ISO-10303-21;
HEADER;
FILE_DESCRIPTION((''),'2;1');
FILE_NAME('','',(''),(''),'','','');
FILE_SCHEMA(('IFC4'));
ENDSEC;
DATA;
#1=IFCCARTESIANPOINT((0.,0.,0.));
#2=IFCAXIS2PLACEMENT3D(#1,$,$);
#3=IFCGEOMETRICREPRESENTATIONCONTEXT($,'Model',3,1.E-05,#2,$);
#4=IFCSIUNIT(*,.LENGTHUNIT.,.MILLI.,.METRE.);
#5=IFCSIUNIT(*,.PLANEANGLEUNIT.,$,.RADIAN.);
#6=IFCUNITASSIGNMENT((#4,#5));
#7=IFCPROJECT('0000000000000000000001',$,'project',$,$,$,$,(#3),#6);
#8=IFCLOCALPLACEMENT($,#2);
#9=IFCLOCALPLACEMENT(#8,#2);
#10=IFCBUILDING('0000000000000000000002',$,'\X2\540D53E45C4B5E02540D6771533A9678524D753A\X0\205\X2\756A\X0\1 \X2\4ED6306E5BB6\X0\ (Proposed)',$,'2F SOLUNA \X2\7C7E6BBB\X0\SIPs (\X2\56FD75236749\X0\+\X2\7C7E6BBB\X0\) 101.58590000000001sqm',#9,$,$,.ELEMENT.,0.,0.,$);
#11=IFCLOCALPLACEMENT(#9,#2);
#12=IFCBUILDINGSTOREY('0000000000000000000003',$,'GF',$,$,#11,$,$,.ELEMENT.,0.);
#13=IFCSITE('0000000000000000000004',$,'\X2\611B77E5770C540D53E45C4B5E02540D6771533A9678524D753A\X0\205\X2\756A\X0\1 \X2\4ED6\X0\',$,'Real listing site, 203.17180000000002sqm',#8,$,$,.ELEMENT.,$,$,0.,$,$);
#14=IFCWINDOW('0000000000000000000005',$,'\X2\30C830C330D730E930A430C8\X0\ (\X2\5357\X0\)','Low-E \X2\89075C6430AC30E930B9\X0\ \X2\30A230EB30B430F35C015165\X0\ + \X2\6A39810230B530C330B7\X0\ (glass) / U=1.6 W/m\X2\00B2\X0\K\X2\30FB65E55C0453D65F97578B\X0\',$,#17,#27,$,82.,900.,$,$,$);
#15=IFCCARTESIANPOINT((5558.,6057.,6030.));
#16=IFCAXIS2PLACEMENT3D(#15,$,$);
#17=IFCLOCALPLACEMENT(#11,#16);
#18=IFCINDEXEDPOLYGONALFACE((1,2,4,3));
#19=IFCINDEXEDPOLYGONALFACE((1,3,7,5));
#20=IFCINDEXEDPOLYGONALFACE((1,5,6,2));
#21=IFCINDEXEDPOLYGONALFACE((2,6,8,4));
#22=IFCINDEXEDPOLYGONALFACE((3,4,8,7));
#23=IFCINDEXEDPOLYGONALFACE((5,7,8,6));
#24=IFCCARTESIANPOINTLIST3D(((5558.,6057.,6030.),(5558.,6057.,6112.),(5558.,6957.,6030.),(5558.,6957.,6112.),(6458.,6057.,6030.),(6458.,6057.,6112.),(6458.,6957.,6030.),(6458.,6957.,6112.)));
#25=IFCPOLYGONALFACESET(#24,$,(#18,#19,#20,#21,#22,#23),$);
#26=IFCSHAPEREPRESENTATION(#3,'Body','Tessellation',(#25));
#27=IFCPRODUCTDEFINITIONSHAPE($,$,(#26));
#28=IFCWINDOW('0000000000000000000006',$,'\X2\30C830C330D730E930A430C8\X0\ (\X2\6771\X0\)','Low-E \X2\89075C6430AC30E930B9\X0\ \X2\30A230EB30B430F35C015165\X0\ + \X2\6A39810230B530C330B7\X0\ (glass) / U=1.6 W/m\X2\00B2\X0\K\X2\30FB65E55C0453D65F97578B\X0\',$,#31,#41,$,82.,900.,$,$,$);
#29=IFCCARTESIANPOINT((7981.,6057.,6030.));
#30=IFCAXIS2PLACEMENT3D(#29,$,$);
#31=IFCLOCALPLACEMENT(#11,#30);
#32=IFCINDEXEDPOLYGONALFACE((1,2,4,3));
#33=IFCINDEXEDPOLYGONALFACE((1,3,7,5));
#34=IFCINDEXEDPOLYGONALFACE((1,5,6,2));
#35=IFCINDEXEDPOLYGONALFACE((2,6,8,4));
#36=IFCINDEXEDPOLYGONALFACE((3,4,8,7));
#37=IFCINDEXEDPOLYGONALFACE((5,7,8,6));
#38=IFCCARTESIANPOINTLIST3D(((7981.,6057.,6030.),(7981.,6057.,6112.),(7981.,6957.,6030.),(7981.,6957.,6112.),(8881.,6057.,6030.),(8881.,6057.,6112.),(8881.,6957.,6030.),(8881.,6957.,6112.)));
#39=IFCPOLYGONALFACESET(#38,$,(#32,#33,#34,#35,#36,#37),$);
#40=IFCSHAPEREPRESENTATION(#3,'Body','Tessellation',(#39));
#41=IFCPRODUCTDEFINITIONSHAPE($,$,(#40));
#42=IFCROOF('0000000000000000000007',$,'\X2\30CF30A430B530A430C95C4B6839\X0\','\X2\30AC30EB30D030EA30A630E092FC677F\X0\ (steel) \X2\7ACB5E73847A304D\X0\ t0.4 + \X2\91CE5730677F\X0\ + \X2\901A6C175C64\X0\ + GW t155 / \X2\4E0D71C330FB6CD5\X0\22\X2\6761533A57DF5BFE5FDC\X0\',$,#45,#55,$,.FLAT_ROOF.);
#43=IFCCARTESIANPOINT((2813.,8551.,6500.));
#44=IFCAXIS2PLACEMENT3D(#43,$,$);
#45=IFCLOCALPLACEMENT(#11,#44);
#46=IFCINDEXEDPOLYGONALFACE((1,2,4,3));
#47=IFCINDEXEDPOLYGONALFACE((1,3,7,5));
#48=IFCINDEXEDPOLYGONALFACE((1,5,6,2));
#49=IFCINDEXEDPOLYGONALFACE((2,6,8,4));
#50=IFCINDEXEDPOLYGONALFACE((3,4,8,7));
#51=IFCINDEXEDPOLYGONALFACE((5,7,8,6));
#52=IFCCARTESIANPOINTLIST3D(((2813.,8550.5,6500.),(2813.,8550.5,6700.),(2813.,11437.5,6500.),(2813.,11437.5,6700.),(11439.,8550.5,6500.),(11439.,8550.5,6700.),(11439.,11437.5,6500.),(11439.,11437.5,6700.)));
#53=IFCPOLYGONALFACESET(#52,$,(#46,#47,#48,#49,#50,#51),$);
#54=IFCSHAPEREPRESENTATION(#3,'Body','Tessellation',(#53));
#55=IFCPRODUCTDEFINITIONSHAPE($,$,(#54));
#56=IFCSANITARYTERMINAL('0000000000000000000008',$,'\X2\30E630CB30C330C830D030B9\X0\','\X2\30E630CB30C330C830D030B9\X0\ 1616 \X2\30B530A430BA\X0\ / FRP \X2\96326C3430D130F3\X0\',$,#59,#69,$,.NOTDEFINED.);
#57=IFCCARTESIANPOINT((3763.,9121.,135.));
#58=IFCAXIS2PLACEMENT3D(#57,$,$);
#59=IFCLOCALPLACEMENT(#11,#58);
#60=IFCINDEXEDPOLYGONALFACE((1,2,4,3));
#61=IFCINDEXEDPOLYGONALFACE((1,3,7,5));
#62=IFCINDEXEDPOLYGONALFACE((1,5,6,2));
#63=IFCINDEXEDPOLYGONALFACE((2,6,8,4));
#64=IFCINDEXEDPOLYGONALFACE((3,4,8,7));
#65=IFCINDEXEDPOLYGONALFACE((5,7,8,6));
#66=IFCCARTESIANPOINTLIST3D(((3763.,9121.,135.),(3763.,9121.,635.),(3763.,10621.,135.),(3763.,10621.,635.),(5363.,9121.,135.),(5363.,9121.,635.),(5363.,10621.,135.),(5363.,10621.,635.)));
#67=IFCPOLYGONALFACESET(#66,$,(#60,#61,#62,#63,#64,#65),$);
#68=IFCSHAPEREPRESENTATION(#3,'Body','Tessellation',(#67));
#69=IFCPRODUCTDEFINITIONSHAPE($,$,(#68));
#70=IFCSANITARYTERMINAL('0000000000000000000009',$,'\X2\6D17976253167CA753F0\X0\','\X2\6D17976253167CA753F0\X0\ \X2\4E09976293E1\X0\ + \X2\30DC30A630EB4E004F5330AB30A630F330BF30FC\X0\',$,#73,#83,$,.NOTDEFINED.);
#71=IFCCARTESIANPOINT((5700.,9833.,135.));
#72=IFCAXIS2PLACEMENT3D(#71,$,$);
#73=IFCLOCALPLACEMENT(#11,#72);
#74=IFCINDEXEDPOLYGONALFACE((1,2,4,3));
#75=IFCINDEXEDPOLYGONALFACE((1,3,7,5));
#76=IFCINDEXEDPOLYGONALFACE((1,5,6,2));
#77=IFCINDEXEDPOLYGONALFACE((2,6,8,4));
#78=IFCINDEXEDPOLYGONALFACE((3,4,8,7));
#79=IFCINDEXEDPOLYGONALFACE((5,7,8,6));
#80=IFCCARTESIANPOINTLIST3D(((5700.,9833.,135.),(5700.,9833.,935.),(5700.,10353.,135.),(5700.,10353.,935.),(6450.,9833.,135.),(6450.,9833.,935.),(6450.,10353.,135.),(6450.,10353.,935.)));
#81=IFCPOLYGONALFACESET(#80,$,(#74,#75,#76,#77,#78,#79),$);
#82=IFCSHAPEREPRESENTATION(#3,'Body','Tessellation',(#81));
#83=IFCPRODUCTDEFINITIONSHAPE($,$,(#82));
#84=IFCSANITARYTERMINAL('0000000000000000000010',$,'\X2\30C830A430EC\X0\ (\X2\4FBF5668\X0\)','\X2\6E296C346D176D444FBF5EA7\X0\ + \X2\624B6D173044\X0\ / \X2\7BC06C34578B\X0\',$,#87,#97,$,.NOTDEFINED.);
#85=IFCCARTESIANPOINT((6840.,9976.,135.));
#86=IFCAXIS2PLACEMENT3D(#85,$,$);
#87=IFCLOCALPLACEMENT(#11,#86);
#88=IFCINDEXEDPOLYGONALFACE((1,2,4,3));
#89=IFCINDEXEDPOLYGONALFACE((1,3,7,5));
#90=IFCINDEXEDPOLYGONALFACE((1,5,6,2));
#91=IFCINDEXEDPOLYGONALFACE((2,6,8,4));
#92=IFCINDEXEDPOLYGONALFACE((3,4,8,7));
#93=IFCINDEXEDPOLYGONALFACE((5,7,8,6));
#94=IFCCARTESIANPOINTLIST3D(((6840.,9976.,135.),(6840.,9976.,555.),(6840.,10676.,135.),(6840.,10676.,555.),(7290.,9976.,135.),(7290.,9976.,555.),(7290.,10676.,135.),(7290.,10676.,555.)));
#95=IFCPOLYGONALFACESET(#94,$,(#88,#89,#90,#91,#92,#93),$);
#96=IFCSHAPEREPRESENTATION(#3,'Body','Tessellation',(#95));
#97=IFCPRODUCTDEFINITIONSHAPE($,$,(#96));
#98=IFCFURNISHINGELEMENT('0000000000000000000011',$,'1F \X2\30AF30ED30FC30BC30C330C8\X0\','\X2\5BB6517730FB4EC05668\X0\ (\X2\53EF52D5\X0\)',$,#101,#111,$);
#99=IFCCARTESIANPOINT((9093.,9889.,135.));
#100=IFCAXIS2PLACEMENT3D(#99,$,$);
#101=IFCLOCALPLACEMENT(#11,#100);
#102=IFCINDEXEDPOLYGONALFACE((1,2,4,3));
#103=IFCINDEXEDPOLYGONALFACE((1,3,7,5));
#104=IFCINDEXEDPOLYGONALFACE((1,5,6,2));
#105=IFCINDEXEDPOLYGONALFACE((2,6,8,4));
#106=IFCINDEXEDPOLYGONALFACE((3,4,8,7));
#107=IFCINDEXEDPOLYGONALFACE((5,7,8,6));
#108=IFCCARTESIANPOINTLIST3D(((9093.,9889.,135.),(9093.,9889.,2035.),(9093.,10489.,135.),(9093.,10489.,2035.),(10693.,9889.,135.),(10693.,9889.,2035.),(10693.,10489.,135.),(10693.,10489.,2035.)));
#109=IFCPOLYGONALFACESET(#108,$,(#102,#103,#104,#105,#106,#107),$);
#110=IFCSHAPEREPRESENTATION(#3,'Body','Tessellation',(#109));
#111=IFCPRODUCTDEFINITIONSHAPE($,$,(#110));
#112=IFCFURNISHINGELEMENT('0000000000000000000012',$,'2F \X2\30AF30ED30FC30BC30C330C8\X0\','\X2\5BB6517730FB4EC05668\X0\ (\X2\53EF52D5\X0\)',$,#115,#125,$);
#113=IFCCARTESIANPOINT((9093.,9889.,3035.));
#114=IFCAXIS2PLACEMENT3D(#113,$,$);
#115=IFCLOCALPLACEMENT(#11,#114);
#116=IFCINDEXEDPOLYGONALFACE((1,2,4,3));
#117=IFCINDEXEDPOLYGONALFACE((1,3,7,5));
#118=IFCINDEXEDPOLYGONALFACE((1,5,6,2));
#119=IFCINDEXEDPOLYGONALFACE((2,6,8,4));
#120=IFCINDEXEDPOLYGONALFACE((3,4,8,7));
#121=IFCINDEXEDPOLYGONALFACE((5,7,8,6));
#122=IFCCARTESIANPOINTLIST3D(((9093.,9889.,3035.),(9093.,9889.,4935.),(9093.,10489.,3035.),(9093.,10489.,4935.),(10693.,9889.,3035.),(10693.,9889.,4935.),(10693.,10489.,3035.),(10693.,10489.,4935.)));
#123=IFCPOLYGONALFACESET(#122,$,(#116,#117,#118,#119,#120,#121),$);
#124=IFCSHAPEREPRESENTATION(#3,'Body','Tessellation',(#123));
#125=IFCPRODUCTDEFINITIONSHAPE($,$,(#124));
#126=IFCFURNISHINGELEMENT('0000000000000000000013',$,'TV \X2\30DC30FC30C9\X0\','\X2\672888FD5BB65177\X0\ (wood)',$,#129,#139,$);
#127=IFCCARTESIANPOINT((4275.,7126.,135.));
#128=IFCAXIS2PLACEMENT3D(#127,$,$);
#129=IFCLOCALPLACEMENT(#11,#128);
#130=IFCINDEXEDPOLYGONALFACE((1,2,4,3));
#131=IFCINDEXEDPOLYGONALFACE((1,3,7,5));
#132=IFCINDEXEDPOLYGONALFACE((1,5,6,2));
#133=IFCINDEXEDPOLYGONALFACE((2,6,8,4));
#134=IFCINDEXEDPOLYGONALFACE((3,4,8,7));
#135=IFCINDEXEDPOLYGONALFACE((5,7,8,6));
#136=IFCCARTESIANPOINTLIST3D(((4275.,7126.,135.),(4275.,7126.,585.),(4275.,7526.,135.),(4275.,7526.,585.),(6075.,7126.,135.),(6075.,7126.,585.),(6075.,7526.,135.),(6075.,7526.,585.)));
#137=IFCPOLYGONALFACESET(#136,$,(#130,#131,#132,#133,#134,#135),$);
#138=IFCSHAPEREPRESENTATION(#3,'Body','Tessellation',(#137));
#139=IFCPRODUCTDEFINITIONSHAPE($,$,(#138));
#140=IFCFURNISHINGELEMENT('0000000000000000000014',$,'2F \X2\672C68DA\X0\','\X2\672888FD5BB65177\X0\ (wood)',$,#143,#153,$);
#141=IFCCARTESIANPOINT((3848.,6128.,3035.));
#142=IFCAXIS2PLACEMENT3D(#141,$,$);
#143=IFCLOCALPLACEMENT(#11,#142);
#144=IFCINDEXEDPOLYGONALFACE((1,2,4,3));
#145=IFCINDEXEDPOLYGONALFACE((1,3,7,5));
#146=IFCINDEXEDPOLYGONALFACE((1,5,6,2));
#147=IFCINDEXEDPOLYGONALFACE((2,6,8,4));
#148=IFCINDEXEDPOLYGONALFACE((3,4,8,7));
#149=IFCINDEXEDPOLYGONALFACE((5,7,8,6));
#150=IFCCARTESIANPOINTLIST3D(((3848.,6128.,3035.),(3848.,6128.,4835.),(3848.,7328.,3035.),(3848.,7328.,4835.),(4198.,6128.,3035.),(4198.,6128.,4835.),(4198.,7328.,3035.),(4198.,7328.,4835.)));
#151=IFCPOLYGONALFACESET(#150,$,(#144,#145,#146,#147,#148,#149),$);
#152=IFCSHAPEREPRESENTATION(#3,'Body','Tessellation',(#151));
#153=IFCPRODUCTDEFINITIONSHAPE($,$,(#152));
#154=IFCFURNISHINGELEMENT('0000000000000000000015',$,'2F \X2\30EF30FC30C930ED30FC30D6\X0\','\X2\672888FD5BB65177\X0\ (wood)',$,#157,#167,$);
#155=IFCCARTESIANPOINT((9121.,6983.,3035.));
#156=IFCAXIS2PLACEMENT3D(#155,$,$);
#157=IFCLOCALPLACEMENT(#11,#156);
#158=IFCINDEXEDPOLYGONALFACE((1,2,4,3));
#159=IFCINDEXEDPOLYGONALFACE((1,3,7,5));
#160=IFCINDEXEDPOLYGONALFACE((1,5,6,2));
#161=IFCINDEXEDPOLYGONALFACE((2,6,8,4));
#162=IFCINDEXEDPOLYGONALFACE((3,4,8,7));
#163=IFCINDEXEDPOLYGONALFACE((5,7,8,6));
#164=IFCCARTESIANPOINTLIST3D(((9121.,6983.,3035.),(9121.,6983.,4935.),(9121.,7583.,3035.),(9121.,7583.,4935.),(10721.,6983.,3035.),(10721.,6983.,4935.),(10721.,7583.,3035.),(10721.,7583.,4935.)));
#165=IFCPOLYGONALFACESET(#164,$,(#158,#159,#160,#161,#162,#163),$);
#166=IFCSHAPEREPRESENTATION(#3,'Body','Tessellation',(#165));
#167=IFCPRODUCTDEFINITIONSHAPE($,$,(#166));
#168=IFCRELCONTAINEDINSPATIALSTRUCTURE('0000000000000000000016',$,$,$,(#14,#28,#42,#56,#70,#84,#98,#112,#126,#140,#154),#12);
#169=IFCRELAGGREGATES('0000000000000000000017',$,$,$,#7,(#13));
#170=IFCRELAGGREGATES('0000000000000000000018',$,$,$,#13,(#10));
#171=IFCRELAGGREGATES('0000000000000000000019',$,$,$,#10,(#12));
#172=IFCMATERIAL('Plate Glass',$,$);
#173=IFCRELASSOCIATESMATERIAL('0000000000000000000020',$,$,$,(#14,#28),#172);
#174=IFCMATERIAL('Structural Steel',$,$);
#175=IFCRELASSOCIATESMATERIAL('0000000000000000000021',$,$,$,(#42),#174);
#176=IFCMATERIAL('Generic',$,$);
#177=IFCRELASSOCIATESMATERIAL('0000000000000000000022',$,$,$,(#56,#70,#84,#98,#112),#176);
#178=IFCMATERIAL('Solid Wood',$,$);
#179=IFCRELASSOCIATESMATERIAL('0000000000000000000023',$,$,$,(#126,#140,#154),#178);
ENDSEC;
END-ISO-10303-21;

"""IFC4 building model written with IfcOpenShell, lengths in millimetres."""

from ifc_helpers import new_model, si_unit, frame, frame_2d, origin, place, context, project, spatial, rectangle, extrude, material, element, save


model = new_model("IFC4")

# Units and contexts
model_context = context("Model", 3, precision=1e-05, world=origin())
ifc_project = project(units=[si_unit("LENGTHUNIT", "METRE", prefix="MILLI"), si_unit("PLANEANGLEUNIT", "RADIAN")], contexts=[model_context])

# Site, building, storey
site_placement = place(None, origin())
site = spatial("IfcSite", under=ifc_project, at=site_placement, Name="愛知県名古屋市名東区陸前町205番1 他", ObjectType="Real listing site, 203.17180000000002sqm", CompositionType="ELEMENT", RefElevation=0.0)
building_placement = place(site_placement, origin())
building = spatial("IfcBuilding", under=site, at=building_placement, Name="名古屋市名東区陸前町205番1 他の家 (Proposed)", ObjectType="2F SOLUNA 籾殻SIPs (国産杉+籾殻) 101.58590000000001sqm", CompositionType="ELEMENT", ElevationOfRefHeight=0.0, ElevationOfTerrain=0.0)
storey_placement = place(building_placement, origin())
storey = spatial("IfcBuildingStorey", under=building, at=storey_placement, Name="GF", CompositionType="ELEMENT", Elevation=0.0)

# Shared definitions
ifc_material_1 = material(Name="Solid Wood")
ifc_material_2 = material(Name="Plate Glass")

# Windows
window_1_placement = place(storey_placement, frame((5558.0, 6057.0, 6030.0)))
element("IfcWindow", 1, at=window_1_placement, inside=storey, material=ifc_material_2, Name="トップライト (南)", Description="Low-E 複層ガラス アルゴン封入 + 樹脂サッシ (glass) / U=1.6 W/m²K・日射取得型", OverallHeight=82.0, OverallWidth=900.0, context=model_context, shape_type="SweptSolid", body=[
    extrude(rectangle(XDim=900.0, YDim=900.0, at=frame_2d((450.0, 450.0))), frame((5558.0, 6057.0, 6030.0)), (0.0, 0.0, 1.0), 82.0),
])
window_2_placement = place(storey_placement, frame((7981.0, 6057.0, 6030.0)))
element("IfcWindow", 2, at=window_2_placement, inside=storey, material=ifc_material_2, Name="トップライト (東)", Description="Low-E 複層ガラス アルゴン封入 + 樹脂サッシ (glass) / U=1.6 W/m²K・日射取得型", OverallHeight=82.0, OverallWidth=900.0, context=model_context, shape_type="SweptSolid", body=[
    extrude(rectangle(XDim=900.0, YDim=900.0, at=frame_2d((450.0, 450.0))), frame((7981.0, 6057.0, 6030.0)), (0.0, 0.0, 1.0), 82.0),
])

# Roof
ifc_material_3 = material(Name="Structural Steel")
roof_placement = place(storey_placement, frame((2813.0, 8551.0, 6500.0)))
element("IfcRoof", 3, at=roof_placement, inside=storey, material=ifc_material_3, Name="ハイサイド屋根", Description="ガルバリウム鋼板 (steel) 立平葺き t0.4 + 野地板 + 通気層 + GW t155 / 不燃・法22条区域対応", PredefinedType="FLAT_ROOF", context=model_context, shape_type="SweptSolid", body=[
    extrude(rectangle(XDim=8626.0, YDim=2887.0, at=frame_2d((4313.0, 1443.0))), frame((2813.0, 8551.0, 6500.0)), (0.0, 0.0, 1.0), 200.0),
])

# Sanitary terminals
ifc_material_4 = material(Name="Generic")
sanitary_terminal_1_placement = place(storey_placement, frame((3763.0, 9121.0, 135.0)))
element("IfcSanitaryTerminal", 4, at=sanitary_terminal_1_placement, inside=storey, material=ifc_material_4, Name="ユニットバス", Description="ユニットバス 1616 サイズ / FRP 防水パン", PredefinedType="NOTDEFINED", context=model_context, shape_type="SweptSolid", body=[
    extrude(rectangle(XDim=1600.0, YDim=1500.0, at=frame_2d((800.0, 750.0))), frame((3763.0, 9121.0, 135.0)), (0.0, 0.0, 1.0), 500.0),
])
sanitary_terminal_2_placement = place(storey_placement, frame((5700.0, 9833.0, 135.0)))
element("IfcSanitaryTerminal", 5, at=sanitary_terminal_2_placement, inside=storey, material=ifc_material_4, Name="洗面化粧台", Description="洗面化粧台 三面鏡 + ボウル一体カウンター", PredefinedType="NOTDEFINED", context=model_context, shape_type="SweptSolid", body=[
    extrude(rectangle(XDim=750.0, YDim=520.0, at=frame_2d((375.0, 260.0))), frame((5700.0, 9833.0, 135.0)), (0.0, 0.0, 1.0), 800.0),
])
sanitary_terminal_3_placement = place(storey_placement, frame((6840.0, 9976.0, 135.0)))
element("IfcSanitaryTerminal", 6, at=sanitary_terminal_3_placement, inside=storey, material=ifc_material_4, Name="トイレ (便器)", Description="温水洗浄便座 + 手洗い / 節水型", PredefinedType="NOTDEFINED", context=model_context, shape_type="SweptSolid", body=[
    extrude(rectangle(XDim=450.0, YDim=700.0, at=frame_2d((225.0, 350.0))), frame((6840.0, 9976.0, 135.0)), (0.0, 0.0, 1.0), 420.0),
])

# Furnishing elements
furnishing_1_placement = place(storey_placement, frame((9093.0, 9889.0, 135.0)))
element("IfcFurnishingElement", 7, at=furnishing_1_placement, inside=storey, material=ifc_material_4, Name="1F クローゼット", Description="家具・什器 (可動)", context=model_context, shape_type="SweptSolid", body=[
    extrude(rectangle(XDim=1600.0, YDim=600.0, at=frame_2d((800.0, 300.0))), frame((9093.0, 9889.0, 135.0)), (0.0, 0.0, 1.0), 1900.0),
])
furnishing_2_placement = place(storey_placement, frame((9093.0, 9889.0, 3035.0)))
element("IfcFurnishingElement", 8, at=furnishing_2_placement, inside=storey, material=ifc_material_4, Name="2F クローゼット", Description="家具・什器 (可動)", context=model_context, shape_type="SweptSolid", body=[
    extrude(rectangle(XDim=1600.0, YDim=600.0, at=frame_2d((800.0, 300.0))), frame((9093.0, 9889.0, 3035.0)), (0.0, 0.0, 1.0), 1900.0),
])
furnishing_3_placement = place(storey_placement, frame((4275.0, 7126.0, 135.0)))
element("IfcFurnishingElement", 9, at=furnishing_3_placement, inside=storey, material=ifc_material_1, Name="TV ボード", Description="木製家具 (wood)", context=model_context, shape_type="SweptSolid", body=[
    extrude(rectangle(XDim=1800.0, YDim=400.0, at=frame_2d((900.0, 200.0))), frame((4275.0, 7126.0, 135.0)), (0.0, 0.0, 1.0), 450.0),
])
furnishing_4_placement = place(storey_placement, frame((3848.0, 6128.0, 3035.0)))
element("IfcFurnishingElement", 10, at=furnishing_4_placement, inside=storey, material=ifc_material_1, Name="2F 本棚", Description="木製家具 (wood)", context=model_context, shape_type="SweptSolid", body=[
    extrude(rectangle(XDim=350.0, YDim=1200.0, at=frame_2d((175.0, 600.0))), frame((3848.0, 6128.0, 3035.0)), (0.0, 0.0, 1.0), 1800.0),
])
furnishing_5_placement = place(storey_placement, frame((9121.0, 6983.0, 3035.0)))
element("IfcFurnishingElement", 11, at=furnishing_5_placement, inside=storey, material=ifc_material_1, Name="2F ワードローブ", Description="木製家具 (wood)", context=model_context, shape_type="SweptSolid", body=[
    extrude(rectangle(XDim=1600.0, YDim=600.0, at=frame_2d((800.0, 300.0))), frame((9121.0, 6983.0, 3035.0)), (0.0, 0.0, 1.0), 1900.0),
])

save(model, "model.ifc")
